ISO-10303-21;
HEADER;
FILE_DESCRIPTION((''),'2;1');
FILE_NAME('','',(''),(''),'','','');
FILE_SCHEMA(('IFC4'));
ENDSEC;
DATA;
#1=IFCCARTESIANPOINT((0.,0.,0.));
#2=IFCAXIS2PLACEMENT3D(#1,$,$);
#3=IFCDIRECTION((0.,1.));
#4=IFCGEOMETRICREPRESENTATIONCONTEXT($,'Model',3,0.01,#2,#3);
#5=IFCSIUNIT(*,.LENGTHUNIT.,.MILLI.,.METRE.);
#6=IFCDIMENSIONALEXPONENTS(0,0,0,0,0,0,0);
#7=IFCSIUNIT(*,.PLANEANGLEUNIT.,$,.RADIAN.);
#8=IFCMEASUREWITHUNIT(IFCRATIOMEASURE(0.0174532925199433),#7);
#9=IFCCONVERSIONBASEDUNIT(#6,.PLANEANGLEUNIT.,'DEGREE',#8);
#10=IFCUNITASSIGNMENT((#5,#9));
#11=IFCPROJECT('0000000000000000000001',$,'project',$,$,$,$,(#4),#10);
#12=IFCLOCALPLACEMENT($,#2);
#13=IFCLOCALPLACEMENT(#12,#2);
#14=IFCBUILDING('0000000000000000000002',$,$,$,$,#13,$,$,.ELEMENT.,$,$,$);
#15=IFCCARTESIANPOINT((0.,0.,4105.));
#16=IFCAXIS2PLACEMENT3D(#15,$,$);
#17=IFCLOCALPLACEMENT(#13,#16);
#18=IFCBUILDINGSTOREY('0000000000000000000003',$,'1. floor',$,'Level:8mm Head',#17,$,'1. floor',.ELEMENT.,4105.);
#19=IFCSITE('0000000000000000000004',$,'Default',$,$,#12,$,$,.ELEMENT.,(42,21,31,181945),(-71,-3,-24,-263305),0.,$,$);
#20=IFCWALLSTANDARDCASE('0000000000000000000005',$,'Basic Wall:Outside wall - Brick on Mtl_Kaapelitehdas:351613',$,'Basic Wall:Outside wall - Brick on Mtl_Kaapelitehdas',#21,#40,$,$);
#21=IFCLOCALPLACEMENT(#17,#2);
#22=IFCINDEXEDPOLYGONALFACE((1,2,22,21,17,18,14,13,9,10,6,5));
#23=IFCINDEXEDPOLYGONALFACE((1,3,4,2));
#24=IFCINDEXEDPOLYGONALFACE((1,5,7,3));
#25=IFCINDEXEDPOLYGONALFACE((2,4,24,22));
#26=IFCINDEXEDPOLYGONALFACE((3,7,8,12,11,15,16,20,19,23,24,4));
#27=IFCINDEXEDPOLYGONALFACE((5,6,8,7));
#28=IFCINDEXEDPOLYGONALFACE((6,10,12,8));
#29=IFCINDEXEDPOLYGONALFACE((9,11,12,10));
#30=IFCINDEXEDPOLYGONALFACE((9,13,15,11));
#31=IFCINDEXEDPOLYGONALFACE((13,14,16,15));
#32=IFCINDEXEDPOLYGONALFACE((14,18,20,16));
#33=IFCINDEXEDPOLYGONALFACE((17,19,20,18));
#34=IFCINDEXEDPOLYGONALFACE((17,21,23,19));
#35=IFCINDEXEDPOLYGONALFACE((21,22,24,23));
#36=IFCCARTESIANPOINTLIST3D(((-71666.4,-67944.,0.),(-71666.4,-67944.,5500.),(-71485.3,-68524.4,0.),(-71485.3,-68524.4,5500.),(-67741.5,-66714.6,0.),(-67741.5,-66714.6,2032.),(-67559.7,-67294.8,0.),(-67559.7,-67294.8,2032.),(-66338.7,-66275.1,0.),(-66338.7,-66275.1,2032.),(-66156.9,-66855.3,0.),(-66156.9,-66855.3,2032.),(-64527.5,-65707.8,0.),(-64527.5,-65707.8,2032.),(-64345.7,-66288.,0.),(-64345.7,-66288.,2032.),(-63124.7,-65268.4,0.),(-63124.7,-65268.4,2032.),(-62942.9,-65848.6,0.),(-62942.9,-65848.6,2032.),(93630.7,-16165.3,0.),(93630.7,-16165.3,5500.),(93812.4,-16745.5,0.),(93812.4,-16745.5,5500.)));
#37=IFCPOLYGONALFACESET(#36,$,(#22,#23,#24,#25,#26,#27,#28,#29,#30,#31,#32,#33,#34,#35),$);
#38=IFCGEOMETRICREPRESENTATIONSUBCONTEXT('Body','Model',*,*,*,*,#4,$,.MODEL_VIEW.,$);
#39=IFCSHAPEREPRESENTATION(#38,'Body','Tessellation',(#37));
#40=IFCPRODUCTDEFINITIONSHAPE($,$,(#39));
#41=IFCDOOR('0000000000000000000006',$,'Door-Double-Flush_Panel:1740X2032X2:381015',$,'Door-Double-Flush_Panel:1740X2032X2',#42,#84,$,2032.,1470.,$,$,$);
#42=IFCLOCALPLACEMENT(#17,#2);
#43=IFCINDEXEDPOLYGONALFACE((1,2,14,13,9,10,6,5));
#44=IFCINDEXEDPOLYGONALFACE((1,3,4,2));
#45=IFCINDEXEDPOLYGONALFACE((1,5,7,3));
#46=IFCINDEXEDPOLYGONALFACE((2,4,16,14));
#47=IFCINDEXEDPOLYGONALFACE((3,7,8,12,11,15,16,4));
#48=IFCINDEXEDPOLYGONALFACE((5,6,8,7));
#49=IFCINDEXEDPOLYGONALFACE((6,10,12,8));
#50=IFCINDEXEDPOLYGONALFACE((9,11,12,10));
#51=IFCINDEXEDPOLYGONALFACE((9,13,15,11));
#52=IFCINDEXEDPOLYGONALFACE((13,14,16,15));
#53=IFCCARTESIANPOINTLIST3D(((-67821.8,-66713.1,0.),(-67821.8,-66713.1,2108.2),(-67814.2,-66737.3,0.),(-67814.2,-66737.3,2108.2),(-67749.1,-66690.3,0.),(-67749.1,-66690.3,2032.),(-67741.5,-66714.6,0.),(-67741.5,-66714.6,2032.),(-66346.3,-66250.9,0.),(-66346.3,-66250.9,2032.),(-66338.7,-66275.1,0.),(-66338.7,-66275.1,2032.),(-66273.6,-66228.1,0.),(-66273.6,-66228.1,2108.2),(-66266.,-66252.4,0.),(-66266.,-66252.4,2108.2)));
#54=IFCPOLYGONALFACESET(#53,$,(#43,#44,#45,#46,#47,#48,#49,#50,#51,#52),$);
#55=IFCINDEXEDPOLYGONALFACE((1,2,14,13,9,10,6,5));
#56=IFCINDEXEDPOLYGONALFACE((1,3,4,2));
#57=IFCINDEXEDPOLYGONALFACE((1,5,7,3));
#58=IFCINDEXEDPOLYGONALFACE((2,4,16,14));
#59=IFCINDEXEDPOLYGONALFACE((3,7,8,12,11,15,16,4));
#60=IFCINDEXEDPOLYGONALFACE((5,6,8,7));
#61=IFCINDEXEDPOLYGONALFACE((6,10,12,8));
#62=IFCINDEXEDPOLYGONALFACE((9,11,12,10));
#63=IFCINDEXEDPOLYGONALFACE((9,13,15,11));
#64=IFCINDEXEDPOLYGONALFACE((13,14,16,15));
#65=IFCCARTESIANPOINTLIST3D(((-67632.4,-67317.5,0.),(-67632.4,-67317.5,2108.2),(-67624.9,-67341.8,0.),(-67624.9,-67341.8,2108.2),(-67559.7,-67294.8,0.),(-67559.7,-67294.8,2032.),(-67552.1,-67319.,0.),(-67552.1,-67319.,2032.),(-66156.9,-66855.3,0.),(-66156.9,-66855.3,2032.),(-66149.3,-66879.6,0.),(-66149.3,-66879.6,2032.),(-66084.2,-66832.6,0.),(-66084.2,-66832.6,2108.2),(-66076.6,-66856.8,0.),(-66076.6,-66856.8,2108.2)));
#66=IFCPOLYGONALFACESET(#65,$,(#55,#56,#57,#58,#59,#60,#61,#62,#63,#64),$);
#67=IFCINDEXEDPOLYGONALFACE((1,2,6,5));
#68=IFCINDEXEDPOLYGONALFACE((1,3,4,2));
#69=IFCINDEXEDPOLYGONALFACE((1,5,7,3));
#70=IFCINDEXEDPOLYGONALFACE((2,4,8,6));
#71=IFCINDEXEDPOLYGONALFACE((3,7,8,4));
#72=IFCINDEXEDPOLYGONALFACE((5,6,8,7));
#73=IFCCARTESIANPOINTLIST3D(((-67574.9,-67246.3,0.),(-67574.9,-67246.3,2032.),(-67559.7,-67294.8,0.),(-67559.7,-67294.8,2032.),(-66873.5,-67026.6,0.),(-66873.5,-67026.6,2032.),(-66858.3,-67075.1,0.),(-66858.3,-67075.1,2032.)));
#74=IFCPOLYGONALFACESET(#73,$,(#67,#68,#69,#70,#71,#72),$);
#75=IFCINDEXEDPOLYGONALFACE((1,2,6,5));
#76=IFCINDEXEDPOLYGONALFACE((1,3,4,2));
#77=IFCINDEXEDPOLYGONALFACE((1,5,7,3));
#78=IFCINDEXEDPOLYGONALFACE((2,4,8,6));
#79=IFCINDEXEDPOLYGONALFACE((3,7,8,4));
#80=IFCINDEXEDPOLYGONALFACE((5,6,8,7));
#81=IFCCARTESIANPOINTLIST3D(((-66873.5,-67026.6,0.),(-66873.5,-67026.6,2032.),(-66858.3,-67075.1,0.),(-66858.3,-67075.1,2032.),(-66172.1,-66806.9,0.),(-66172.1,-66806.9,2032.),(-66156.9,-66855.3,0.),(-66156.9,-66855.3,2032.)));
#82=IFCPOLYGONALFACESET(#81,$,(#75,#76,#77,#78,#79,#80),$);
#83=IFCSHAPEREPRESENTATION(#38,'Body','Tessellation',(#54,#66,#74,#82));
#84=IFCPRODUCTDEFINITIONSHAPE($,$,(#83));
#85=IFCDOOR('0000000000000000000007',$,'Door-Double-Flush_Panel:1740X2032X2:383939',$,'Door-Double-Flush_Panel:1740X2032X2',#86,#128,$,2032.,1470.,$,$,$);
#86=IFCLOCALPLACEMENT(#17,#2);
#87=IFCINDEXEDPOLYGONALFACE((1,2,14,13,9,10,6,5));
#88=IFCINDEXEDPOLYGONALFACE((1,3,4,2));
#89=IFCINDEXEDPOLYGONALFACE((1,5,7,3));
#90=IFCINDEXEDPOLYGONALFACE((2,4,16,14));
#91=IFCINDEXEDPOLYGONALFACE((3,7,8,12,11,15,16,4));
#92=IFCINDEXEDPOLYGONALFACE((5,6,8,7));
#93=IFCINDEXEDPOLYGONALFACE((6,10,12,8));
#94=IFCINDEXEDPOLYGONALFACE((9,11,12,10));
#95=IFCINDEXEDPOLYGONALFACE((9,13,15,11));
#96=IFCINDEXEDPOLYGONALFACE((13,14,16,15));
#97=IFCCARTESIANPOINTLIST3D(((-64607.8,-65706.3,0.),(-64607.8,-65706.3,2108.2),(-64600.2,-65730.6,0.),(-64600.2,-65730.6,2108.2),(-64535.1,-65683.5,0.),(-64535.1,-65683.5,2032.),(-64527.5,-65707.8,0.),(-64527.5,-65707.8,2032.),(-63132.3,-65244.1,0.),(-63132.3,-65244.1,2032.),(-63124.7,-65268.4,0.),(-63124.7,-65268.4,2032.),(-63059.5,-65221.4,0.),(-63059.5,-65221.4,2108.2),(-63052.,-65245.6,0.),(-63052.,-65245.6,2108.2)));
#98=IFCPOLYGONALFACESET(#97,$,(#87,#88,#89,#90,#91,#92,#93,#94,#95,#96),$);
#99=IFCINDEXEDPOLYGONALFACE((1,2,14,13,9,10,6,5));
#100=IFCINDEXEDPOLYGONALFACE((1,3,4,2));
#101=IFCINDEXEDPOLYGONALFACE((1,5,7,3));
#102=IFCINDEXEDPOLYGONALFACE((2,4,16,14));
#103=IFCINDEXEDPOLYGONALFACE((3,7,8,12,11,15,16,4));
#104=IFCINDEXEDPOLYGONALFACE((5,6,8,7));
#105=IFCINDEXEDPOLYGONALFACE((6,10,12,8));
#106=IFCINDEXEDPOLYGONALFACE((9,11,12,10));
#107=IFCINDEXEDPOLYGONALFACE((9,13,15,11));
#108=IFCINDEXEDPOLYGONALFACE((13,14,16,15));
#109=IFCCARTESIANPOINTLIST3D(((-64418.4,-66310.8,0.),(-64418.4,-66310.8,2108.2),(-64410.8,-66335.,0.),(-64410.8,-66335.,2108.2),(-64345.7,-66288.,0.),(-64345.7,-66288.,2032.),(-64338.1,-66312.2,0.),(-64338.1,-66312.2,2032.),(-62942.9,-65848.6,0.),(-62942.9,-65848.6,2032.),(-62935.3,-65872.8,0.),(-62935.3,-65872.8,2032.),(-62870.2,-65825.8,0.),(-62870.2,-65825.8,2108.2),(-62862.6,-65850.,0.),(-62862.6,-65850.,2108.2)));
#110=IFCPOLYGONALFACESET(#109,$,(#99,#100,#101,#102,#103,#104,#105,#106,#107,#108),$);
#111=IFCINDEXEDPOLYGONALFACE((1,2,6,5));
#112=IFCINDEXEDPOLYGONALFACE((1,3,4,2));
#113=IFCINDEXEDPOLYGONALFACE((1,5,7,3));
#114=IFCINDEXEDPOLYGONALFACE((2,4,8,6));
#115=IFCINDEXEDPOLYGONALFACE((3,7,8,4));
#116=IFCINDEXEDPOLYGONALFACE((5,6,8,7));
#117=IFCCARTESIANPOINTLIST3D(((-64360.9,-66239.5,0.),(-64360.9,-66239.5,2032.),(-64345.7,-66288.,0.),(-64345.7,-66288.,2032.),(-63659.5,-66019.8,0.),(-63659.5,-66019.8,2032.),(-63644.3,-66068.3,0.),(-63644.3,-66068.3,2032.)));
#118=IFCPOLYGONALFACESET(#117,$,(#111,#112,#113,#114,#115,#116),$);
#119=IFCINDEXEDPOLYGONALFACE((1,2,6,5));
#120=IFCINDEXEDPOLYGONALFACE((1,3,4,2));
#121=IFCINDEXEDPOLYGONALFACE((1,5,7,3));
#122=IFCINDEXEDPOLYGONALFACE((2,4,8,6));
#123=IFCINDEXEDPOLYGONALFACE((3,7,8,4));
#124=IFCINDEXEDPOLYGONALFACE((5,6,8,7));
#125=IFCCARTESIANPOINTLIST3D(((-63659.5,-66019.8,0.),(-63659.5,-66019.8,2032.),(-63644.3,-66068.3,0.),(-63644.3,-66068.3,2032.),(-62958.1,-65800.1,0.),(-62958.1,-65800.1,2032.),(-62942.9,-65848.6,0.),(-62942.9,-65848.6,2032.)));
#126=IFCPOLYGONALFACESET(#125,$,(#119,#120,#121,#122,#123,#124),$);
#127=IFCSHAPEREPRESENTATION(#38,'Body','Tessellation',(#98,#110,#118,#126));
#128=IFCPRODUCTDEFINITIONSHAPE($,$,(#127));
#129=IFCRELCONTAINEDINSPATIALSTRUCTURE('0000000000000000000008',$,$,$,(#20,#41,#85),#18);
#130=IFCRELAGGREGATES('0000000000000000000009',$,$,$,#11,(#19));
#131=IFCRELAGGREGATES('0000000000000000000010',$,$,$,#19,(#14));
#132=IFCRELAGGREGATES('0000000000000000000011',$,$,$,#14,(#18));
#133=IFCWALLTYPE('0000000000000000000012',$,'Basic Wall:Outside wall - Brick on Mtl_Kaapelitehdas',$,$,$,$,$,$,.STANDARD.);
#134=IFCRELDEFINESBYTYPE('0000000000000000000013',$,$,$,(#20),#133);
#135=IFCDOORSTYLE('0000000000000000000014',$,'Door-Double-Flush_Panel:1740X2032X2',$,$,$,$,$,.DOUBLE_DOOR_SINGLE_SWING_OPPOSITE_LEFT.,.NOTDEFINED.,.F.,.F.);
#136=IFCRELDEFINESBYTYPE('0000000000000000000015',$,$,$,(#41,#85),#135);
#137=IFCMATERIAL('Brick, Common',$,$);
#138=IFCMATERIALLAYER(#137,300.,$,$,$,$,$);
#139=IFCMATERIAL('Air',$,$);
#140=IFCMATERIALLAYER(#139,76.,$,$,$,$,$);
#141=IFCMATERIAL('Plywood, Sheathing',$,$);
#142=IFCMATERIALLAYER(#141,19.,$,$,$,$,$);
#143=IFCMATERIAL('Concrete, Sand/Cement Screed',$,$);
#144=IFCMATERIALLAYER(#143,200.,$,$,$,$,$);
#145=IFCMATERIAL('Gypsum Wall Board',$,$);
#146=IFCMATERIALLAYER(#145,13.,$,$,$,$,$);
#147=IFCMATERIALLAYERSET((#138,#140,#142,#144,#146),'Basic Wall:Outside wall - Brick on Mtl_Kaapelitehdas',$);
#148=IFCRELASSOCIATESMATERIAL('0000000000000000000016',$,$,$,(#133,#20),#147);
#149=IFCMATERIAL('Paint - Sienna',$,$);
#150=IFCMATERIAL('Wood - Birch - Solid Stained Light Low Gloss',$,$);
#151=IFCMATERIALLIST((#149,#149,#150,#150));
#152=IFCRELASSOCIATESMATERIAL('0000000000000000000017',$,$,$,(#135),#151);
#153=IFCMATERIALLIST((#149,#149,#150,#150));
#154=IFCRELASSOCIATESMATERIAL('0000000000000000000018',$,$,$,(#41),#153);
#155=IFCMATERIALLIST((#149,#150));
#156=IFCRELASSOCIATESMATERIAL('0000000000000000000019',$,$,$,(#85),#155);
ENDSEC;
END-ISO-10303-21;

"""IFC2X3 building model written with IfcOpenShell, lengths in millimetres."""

from ifc_helpers import new_model, entity, si_unit, converted_unit, direction, frame, frame_2d, origin, origin_2d_with_axis, place, context, subcontext, project, spatial, polyline, rectangle, outline, extrude, source, transform, mapped, material, material_list, layer, layer_set, layer_usage, type_object, type_shapes, element, fill, save


model = new_model("IFC2X3")

# Units and contexts
model_context = context("Model", 3, precision=0.01, world=origin(), true_north=direction((0.0, 1.0)))
body_context = subcontext(model_context, "Body", "Model", "MODEL_VIEW")
ifc_project = project(units=[si_unit("LENGTHUNIT", "METRE", prefix="MILLI"), converted_unit("PLANEANGLEUNIT", "DEGREE", entity("IfcRatioMeasure", 0.0174532925199433), si_unit("PLANEANGLEUNIT", "RADIAN"), dimensions=[0, 0, 0, 0, 0, 0, 0])], contexts=[model_context])

# Site, building, storey
site_placement = place(None, origin())
site = spatial("IfcSite", under=ifc_project, at=site_placement, Name="Default", CompositionType="ELEMENT", RefLatitude=(42, 21, 31, 181945), RefLongitude=(-71, -3, -24, -263305), RefElevation=0.0)
building_placement = place(site_placement, origin())
building = spatial("IfcBuilding", under=site, at=building_placement, CompositionType="ELEMENT")
storey_placement = place(building_placement, frame((0.0, 0.0, 4105.0)))
storey = spatial("IfcBuildingStorey", under=building, at=storey_placement, Name="1. floor", ObjectType="Level:8mm Head", LongName="1. floor", CompositionType="ELEMENT", Elevation=4105.0)

# Wall, openings, doors
ifc_material_1 = material(Name="Brick, Common")
ifc_layer_1 = layer(ifc_material_1, 300.0)
ifc_material_2 = material(Name="Air")
ifc_layer_2 = layer(ifc_material_2, 76.0)
ifc_material_3 = material(Name="Plywood, Sheathing")
ifc_layer_3 = layer(ifc_material_3, 19.0)
ifc_material_4 = material(Name="Concrete, Sand/Cement Screed")
ifc_layer_4 = layer(ifc_material_4, 200.0)
ifc_material_5 = material(Name="Gypsum Wall Board")
ifc_layer_5 = layer(ifc_material_5, 13.0)
ifc_layer_set_1 = layer_set([ifc_layer_1, ifc_layer_2, ifc_layer_3, ifc_layer_4, ifc_layer_5], Name="Basic Wall:Outside wall - Brick on Mtl_Kaapelitehdas")
ifc_layer_usage_1 = layer_usage(ifc_layer_set_1, "AXIS2", "NEGATIVE", 304.0)
wall_type_1 = type_object("IfcWallType", Name="Basic Wall:Outside wall - Brick on Mtl_Kaapelitehdas", PredefinedType="STANDARD", material=ifc_layer_set_1)
wall_1_placement = place(storey_placement, frame((93721.6, -16455.4, 0.0), z_axis=(0.0, 0.0, 1.0), x_axis=(-0.954277, -0.298924, 0.0)))
wall_1 = element("IfcWallStandardCase", 1, at=wall_1_placement, inside=storey, type_object=wall_type_1, material=ifc_layer_usage_1, Name="Basic Wall:Outside wall - Brick on Mtl_Kaapelitehdas:351613", ObjectType="Basic Wall:Outside wall - Brick on Mtl_Kaapelitehdas", context=body_context, shape_type="SweptSolid", body=[
    extrude(outline(polyline([(0.0, -304.0), (608.0, -304.0), (163156.9, -304.0), (163280.9, -304.0), (169244.1, -304.0), (169704.1, -304.0), (172609.1, -304.0), (173217.1, -304.0), (173217.8, 304.0), (0.0, 304.0), (0.0, -304.0)])), origin(), (0.0, 0.0, 1.0), 5500.0),
])
opening_1_placement = place(wall_1_placement, frame((167634.1, -304.0, 0.0)))
opening_1 = element("IfcOpeningElement", 2, at=opening_1_placement, cuts=wall_1, ObjectType="Opening", context=body_context, shape_type="SweptSolid", body=[
    extrude(rectangle(XDim=2032.0, YDim=1470.0, at=frame_2d((1016.0, 735.0), x_axis=(1.0, 0.0))), frame((0.0, 0.0, 0.0), z_axis=(0.0, 1.0, 0.0), x_axis=(0.0, 0.0, 1.0)), (0.0, 0.0, 1.0), 608.0),
])
opening_2_placement = place(wall_1_placement, frame((164266.1, -304.0, 0.0)))
opening_2 = element("IfcOpeningElement", 3, at=opening_2_placement, cuts=wall_1, ObjectType="Opening", context=body_context, shape_type="SweptSolid", body=[
    extrude(rectangle(XDim=2032.0, YDim=1470.0, at=frame_2d((1016.0, 735.0), x_axis=(1.0, 0.0))), frame((0.0, 0.0, 0.0), z_axis=(0.0, 1.0, 0.0), x_axis=(0.0, 0.0, 1.0)), (0.0, 0.0, 1.0), 608.0),
])
ifc_material_6 = material(Name="Paint - Sienna")
ifc_material_7 = material(Name="Wood - Birch - Solid Stained Light Low Gloss")
ifc_material_list_1 = material_list([ifc_material_6, ifc_material_6, ifc_material_7, ifc_material_7])
ifc_material_list_2 = material_list([ifc_material_6, ifc_material_6, ifc_material_7, ifc_material_7])
door_style_1 = type_object("IfcDoorStyle", Name="Door-Double-Flush_Panel:1740X2032X2", ConstructionType="NOTDEFINED", OperationType="DOUBLE_DOOR_SINGLE_SWING_OPPOSITE_LEFT", ParameterTakesPrecedence=False, Sizeable=False, material=ifc_material_list_2)
shared_shape_1 = source(origin(), body_context, "Body", "SweptSolid", [
    extrude(outline(polyline([(-997.0, 735.0), (1035.0, 735.0), (1035.0, 811.2), (-1073.2, 811.2), (-1073.2, -811.2), (1035.0, -811.2), (1035.0, -735.0), (-997.0, -735.0), (-997.0, 735.0)])), frame((735.0, -25.4, 1035.0), z_axis=(0.0, 1.0, 0.0), x_axis=(0.0, 0.0, -1.0)), (0.0, 0.0, 1.0), 25.4),
    extrude(outline(polyline([(-997.0, 735.0), (1035.0, 735.0), (1035.0, 811.2), (-1073.2, 811.2), (-1073.2, -811.2), (1035.0, -811.2), (1035.0, -735.0), (-997.0, -735.0), (-997.0, 735.0)])), frame((735.0, 608.0, 1035.0), z_axis=(0.0, 1.0, 0.0), x_axis=(0.0, 0.0, -1.0)), (0.0, 0.0, 1.0), 25.4),
    extrude(rectangle(XDim=50.8, YDim=735.0, at=origin_2d_with_axis()), frame((1102.5, 582.6, 0.0), z_axis=(0.0, 0.0, 1.0), x_axis=(0.0, -1.0, 0.0)), (0.0, 0.0, 1.0), 2032.0),
    extrude(rectangle(XDim=50.8, YDim=735.0, at=frame_2d((0.0, 0.0), x_axis=(1.0, 0.0))), frame((367.5, 582.6, 0.0), z_axis=(0.0, 0.0, 1.0), x_axis=(0.0, -1.0, 0.0)), (0.0, 0.0, 1.0), 2032.0),
])
type_shapes(door_style_1, [shared_shape_1])
door_1_placement = place(opening_1_placement, origin())
door_1 = element("IfcDoor", 4, at=door_1_placement, inside=storey, type_object=door_style_1, material=ifc_material_list_1, Name="Door-Double-Flush_Panel:1740X2032X2:381015", ObjectType="Door-Double-Flush_Panel:1740X2032X2", OverallHeight=2032.0, OverallWidth=1470.0, context=body_context, shape_type="MappedRepresentation", body=[
    mapped(shared_shape_1, transform((0.0, 0.0, 0.0), scale=1.0)),
])
fill(opening_1, door_1)
ifc_material_list_3 = material_list([ifc_material_6, ifc_material_7])
door_2_placement = place(opening_2_placement, origin())
door_2 = element("IfcDoor", 5, at=door_2_placement, inside=storey, type_object=door_style_1, material=ifc_material_list_3, Name="Door-Double-Flush_Panel:1740X2032X2:383939", ObjectType="Door-Double-Flush_Panel:1740X2032X2", OverallHeight=2032.0, OverallWidth=1470.0, context=body_context, shape_type="MappedRepresentation", body=[
    mapped(shared_shape_1, transform((0.0, 0.0, 0.0), scale=1.0)),
])
fill(opening_2, door_2)

save(model, "model.ifc")
